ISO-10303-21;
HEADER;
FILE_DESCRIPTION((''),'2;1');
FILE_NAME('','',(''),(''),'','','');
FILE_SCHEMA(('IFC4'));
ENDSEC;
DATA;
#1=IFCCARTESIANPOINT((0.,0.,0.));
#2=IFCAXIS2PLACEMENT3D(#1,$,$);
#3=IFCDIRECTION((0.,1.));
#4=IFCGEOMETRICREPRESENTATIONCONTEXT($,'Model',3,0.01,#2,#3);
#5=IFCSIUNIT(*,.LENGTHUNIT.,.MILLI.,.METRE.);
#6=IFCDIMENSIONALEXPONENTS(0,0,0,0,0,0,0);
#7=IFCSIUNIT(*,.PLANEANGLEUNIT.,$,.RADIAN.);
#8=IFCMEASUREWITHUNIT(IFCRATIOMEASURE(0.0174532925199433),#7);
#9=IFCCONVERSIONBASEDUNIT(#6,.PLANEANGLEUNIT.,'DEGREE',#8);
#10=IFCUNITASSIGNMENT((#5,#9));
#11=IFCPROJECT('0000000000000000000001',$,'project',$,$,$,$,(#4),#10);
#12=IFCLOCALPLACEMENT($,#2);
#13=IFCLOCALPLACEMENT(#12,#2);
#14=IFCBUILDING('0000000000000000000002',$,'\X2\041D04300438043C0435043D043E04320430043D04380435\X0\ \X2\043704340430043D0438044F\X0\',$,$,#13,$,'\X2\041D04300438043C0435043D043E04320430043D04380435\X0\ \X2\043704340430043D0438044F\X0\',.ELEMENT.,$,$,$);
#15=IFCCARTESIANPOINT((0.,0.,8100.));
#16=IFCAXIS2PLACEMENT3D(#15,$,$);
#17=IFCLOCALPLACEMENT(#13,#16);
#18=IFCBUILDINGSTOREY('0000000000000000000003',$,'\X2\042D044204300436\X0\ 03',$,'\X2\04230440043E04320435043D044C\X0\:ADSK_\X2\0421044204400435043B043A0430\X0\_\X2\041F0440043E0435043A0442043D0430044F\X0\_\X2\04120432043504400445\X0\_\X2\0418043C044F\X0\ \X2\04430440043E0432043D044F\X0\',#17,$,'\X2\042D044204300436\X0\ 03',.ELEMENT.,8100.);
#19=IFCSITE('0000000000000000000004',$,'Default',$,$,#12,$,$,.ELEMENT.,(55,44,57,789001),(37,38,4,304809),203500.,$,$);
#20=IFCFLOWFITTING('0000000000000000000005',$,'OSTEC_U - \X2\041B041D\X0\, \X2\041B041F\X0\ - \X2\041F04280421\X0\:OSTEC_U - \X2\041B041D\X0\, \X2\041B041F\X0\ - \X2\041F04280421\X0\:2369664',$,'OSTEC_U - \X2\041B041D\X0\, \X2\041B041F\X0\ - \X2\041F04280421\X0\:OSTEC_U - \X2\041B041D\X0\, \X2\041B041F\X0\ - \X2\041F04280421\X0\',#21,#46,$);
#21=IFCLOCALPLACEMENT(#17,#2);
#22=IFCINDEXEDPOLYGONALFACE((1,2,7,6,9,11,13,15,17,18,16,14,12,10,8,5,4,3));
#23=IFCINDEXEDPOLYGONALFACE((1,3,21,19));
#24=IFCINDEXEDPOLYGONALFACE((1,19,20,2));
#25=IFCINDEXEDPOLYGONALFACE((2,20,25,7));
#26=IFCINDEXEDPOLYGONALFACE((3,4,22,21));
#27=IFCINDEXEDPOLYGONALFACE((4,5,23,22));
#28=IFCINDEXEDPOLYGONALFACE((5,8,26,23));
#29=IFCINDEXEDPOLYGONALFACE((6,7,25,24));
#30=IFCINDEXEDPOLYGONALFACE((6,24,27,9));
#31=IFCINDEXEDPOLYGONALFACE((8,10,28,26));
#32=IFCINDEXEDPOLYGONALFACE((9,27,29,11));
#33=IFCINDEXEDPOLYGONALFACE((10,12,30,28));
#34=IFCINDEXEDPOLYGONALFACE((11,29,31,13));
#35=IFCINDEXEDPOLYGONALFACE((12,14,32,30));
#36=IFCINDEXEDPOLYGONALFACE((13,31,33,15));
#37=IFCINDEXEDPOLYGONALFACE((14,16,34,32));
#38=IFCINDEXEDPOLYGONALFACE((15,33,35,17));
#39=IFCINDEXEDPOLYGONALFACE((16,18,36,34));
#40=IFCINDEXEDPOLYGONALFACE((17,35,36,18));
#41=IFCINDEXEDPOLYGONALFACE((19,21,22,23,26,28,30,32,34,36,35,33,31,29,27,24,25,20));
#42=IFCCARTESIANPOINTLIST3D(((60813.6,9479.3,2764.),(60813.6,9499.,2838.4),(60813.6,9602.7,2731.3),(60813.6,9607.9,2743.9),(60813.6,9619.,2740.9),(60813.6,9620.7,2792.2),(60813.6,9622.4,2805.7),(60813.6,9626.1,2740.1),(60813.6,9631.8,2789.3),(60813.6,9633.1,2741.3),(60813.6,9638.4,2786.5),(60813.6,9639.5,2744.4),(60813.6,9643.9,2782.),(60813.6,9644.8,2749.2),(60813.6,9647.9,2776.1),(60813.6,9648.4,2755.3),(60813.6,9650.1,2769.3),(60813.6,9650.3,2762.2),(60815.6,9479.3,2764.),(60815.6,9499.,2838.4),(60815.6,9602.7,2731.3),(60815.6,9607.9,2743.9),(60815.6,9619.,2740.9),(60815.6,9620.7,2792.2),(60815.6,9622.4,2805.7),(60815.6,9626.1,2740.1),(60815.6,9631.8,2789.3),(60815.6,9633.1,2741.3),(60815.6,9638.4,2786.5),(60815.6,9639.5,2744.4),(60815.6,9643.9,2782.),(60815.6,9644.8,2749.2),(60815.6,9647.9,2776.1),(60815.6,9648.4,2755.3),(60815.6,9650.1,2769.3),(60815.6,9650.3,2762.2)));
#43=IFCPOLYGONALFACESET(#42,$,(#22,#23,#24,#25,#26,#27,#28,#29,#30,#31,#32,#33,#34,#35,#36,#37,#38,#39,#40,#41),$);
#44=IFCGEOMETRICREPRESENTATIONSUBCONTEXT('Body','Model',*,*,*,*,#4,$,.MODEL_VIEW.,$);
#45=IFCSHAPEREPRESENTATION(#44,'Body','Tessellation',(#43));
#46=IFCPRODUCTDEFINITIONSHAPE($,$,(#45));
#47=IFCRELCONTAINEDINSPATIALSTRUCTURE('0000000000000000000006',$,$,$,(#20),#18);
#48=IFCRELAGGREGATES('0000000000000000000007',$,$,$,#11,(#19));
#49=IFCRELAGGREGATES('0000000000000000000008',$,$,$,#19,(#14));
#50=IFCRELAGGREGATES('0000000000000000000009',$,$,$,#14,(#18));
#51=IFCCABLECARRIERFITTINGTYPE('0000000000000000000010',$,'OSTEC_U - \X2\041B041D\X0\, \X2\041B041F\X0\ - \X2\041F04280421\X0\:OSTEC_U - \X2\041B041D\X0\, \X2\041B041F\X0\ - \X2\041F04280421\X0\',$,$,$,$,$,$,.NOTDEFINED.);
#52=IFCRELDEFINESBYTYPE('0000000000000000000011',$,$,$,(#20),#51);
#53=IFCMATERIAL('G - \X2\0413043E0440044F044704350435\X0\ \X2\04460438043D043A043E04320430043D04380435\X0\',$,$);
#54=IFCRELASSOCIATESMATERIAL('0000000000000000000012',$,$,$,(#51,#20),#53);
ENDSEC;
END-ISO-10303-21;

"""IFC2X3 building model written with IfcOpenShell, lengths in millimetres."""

from ifc_helpers import new_model, entity, si_unit, converted_unit, direction, frame, frame_2d, origin, place, context, subcontext, project, spatial, polyline, circle_curve, parameter, trimmed, segment, composite_curve, outline, extrude, source, transform, mapped, material, type_object, type_shapes, element, save


model = new_model("IFC2X3")

# Units and contexts
model_context = context("Model", 3, precision=0.01, world=origin(), true_north=direction((0.0, 1.0)))
body_context = subcontext(model_context, "Body", "Model", "MODEL_VIEW")
ifc_project = project(units=[si_unit("LENGTHUNIT", "METRE", prefix="MILLI"), converted_unit("PLANEANGLEUNIT", "DEGREE", entity("IfcRatioMeasure", 0.0174532925199433), si_unit("PLANEANGLEUNIT", "RADIAN"), dimensions=[0, 0, 0, 0, 0, 0, 0])], contexts=[model_context])

# Site, building, storey
site_placement = place(None, frame((0.0, 0.0, 0.0)))
site = spatial("IfcSite", under=ifc_project, at=site_placement, Name="Default", CompositionType="ELEMENT", RefLatitude=(55, 44, 57, 789001), RefLongitude=(37, 38, 4, 304809), RefElevation=203500.0)
building_placement = place(site_placement, origin())
building = spatial("IfcBuilding", under=site, at=building_placement, Name="Наименование здания", LongName="Наименование здания", CompositionType="ELEMENT")
storey_placement = place(building_placement, frame((0.0, 0.0, 8100.0)))
storey = spatial("IfcBuildingStorey", under=building, at=storey_placement, Name="Этаж 03", ObjectType="Уровень:ADSK_Стрелка_Проектная_Вверх_Имя уровня", LongName="Этаж 03", CompositionType="ELEMENT", Elevation=8100.0)

# Flow fitting
ifc_material_1 = material(Name="G - Горячее цинкование")
cable_carrier_fitting_type_1 = type_object("IfcCableCarrierFittingType", Name="OSTEC_U - ЛН, ЛП - ПШС:OSTEC_U - ЛН, ЛП - ПШС", PredefinedType="NOTDEFINED", material=ifc_material_1)
shared_shape_1 = source(origin(), body_context, "Body", "SweptSolid", [
    extrude(outline(composite_curve([segment(trimmed(circle_curve(frame_2d((-41.5, 0.0), x_axis=(1.0, 0.0)), 25.0), [parameter(90.0)], [parameter(270.0)], True, "PARAMETER"), True, "CONTINUOUS"), segment(polyline([(-41.5, -25.0), (-30.0, -25.0)]), True, "CONTINUOUS"), segment(polyline([(-30.0, -25.0), (-28.1, -38.5)]), True, "CONTINUOUS"), segment(polyline([(-28.1, -38.5), (99.5, -38.5)]), True, "CONTINUOUS"), segment(polyline([(99.5, -38.5), (99.5, 38.5)]), True, "CONTINUOUS"), segment(polyline([(99.5, 38.5), (-28.1, 38.5)]), True, "CONTINUOUS"), segment(polyline([(-28.1, 38.5), (-30.0, 25.0)]), True, "CONTINUOUS"), segment(polyline([(-30.0, 25.0), (-41.5, 25.0)]), True, "CONTINUOUS")], self_intersect=False)), frame((41.5, 0.0, 0.0)), (0.0, 0.0, 1.0), 2.0),
])
type_shapes(cable_carrier_fitting_type_1, [shared_shape_1])
for number, where, z_axis, x_axis, name in (
    (1, (60813.6, 9625.4, 2765.1), (1.0, 0.0, 0.0), (0.0, -0.966668, 0.256034), "OSTEC_U - ЛН, ЛП - ПШС:OSTEC_U - ЛН, ЛП - ПШС:2369664"),
):
    element("IfcFlowFitting", number, at=place(storey_placement, frame(where, z_axis=z_axis, x_axis=x_axis)), inside=storey, type_object=cable_carrier_fitting_type_1, material=ifc_material_1, Name=name, ObjectType="OSTEC_U - ЛН, ЛП - ПШС:OSTEC_U - ЛН, ЛП - ПШС", context=body_context, shape_type="MappedRepresentation", body=[
        mapped(shared_shape_1, transform((0.0, 0.0, 0.0), scale=1.0)),
    ])

save(model, "model.ifc")
